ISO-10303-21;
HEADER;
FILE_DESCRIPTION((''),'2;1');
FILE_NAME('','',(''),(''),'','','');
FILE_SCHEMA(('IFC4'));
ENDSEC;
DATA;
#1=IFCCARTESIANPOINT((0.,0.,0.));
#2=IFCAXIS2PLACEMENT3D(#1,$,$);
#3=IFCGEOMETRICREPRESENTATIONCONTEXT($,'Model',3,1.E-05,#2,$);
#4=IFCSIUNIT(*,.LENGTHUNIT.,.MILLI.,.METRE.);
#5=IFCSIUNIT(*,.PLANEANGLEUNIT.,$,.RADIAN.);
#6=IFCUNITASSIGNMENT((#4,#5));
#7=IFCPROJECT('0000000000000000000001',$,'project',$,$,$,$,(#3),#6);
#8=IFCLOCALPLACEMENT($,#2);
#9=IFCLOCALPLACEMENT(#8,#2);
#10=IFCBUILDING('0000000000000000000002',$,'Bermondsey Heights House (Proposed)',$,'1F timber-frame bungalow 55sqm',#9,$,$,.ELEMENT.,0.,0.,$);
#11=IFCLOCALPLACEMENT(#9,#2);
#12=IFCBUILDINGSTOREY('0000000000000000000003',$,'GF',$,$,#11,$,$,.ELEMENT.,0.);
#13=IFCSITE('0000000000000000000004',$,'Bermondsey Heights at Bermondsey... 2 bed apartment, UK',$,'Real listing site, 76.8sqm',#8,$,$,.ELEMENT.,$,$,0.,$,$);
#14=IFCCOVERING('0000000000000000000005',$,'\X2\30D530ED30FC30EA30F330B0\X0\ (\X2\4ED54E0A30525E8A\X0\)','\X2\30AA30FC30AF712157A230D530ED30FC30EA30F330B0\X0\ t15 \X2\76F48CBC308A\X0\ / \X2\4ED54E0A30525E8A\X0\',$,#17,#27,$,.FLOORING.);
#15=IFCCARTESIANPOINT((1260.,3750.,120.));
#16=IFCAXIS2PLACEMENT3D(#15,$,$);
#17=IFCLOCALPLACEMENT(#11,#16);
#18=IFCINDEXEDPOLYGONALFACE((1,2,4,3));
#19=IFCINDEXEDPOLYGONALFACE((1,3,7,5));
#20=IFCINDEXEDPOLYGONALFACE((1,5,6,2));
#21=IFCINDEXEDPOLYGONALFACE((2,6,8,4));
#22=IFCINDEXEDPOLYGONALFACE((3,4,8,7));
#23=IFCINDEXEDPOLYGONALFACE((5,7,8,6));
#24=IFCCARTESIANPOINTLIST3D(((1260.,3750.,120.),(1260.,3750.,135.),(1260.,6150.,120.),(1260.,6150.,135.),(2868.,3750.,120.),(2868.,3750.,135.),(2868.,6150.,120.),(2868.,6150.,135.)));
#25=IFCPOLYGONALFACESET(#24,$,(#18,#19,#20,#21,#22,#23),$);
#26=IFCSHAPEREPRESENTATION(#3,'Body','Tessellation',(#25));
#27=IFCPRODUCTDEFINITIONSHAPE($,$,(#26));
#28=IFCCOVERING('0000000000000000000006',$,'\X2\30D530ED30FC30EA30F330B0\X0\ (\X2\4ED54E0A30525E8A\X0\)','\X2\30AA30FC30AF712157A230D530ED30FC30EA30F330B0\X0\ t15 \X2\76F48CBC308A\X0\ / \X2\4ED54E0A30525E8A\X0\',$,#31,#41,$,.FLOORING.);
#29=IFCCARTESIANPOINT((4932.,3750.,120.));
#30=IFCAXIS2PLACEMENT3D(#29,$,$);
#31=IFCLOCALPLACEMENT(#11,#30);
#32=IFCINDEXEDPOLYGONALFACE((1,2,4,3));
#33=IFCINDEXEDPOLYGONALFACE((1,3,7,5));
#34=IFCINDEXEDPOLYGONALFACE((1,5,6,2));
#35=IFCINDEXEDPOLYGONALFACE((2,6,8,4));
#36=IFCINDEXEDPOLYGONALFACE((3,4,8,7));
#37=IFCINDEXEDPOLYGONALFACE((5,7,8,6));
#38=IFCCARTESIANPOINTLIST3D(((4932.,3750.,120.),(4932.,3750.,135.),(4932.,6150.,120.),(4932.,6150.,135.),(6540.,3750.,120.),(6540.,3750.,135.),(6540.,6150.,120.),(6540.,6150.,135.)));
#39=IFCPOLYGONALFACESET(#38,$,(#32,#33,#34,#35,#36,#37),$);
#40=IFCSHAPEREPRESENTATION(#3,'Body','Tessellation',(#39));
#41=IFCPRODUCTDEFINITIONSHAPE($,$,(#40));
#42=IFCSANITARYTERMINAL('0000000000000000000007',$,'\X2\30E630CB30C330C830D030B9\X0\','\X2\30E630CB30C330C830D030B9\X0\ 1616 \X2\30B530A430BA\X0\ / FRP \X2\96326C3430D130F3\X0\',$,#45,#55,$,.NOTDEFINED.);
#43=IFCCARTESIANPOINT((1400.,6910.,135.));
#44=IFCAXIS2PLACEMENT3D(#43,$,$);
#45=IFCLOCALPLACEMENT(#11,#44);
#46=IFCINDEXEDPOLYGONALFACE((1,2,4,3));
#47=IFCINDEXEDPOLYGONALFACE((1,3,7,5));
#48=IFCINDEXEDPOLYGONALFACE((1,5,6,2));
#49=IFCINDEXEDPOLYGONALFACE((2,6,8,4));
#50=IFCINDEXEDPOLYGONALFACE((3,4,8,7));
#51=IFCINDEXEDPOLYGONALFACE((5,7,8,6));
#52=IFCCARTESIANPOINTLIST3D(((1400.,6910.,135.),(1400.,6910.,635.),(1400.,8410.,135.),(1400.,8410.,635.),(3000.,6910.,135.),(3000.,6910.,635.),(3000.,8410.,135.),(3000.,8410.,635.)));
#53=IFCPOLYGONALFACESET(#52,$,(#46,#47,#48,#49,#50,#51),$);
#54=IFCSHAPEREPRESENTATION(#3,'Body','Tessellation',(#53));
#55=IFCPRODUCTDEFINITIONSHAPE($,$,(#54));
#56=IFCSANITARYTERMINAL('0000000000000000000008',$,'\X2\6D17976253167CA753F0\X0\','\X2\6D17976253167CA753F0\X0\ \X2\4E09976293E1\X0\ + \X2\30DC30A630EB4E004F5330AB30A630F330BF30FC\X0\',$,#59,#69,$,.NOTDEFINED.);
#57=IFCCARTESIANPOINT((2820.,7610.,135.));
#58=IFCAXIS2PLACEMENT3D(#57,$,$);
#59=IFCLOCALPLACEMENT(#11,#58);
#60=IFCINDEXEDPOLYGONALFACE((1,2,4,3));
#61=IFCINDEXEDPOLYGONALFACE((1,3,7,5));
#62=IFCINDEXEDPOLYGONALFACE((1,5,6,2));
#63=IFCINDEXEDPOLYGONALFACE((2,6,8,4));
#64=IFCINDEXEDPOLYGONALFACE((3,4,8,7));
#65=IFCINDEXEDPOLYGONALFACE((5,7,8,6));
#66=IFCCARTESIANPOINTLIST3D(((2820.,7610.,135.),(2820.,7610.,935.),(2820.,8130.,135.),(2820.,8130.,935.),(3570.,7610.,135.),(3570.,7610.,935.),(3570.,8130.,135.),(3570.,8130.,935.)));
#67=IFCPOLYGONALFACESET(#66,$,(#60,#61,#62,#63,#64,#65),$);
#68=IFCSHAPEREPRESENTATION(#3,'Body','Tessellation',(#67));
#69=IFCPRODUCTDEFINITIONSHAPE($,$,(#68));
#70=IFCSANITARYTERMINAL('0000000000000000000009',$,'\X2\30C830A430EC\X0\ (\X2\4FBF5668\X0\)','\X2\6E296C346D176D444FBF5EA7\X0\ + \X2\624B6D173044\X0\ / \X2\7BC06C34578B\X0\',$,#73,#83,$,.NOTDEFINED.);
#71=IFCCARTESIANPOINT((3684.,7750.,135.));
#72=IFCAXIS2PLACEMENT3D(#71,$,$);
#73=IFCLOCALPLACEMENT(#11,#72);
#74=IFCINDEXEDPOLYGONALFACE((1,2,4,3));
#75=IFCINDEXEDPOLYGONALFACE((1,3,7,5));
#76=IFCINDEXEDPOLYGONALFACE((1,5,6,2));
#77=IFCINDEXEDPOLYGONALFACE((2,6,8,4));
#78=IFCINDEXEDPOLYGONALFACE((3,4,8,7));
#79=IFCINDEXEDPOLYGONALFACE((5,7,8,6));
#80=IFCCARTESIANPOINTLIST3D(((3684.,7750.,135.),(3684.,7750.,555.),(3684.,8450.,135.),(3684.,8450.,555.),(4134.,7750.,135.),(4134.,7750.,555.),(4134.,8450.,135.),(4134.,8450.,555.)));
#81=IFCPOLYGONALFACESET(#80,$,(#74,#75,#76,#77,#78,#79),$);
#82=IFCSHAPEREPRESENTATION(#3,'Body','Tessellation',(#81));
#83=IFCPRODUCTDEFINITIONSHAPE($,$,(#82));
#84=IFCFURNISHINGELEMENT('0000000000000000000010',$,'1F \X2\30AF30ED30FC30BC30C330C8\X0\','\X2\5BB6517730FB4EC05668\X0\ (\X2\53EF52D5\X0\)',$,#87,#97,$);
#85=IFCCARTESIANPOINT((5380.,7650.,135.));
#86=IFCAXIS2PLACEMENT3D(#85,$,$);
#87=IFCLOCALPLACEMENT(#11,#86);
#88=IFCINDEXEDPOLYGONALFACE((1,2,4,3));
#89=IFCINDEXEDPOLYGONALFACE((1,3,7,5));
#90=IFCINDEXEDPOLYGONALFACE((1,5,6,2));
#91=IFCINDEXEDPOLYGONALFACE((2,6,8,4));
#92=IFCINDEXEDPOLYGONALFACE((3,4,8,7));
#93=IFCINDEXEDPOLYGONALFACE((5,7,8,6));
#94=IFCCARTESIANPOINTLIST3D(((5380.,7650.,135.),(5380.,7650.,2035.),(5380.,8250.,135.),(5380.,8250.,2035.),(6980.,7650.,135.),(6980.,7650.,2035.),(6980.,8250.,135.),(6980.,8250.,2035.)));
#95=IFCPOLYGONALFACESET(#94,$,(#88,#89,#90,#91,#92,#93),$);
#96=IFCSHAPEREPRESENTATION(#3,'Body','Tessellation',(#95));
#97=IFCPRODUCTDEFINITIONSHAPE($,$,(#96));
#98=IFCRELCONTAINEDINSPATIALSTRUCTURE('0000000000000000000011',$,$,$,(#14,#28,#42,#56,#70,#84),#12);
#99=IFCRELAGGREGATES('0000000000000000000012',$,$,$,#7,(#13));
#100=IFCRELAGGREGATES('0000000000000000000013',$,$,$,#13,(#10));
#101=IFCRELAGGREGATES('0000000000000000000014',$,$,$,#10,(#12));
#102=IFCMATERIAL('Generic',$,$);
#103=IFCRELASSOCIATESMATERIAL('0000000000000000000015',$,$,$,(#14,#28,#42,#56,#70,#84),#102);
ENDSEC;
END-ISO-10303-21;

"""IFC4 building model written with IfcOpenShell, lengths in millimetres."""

from ifc_helpers import new_model, si_unit, frame, frame_2d, origin, place, context, project, spatial, rectangle, extrude, material, element, save


model = new_model("IFC4")

# Units and contexts
model_context = context("Model", 3, precision=1e-05, world=origin())
ifc_project = project(units=[si_unit("LENGTHUNIT", "METRE", prefix="MILLI"), si_unit("PLANEANGLEUNIT", "RADIAN")], contexts=[model_context])

# Site, building, storey
site_placement = place(None, origin())
site = spatial("IfcSite", under=ifc_project, at=site_placement, Name="Bermondsey Heights at Bermondsey... 2 bed apartment, UK", ObjectType="Real listing site, 76.8sqm", CompositionType="ELEMENT", RefElevation=0.0)
building_placement = place(site_placement, origin())
building = spatial("IfcBuilding", under=site, at=building_placement, Name="Bermondsey Heights House (Proposed)", ObjectType="1F timber-frame bungalow 55sqm", CompositionType="ELEMENT", ElevationOfRefHeight=0.0, ElevationOfTerrain=0.0)
storey_placement = place(building_placement, origin())
storey = spatial("IfcBuildingStorey", under=building, at=storey_placement, Name="GF", CompositionType="ELEMENT", Elevation=0.0)

# Coverings
ifc_material_1 = material(Name="Generic")
covering_1_placement = place(storey_placement, frame((1260.0, 3750.0, 120.0)))
element("IfcCovering", 1, at=covering_1_placement, inside=storey, material=ifc_material_1, Name="フローリング (仕上げ床)", Description="オーク無垢フローリング t15 直貼り / 仕上げ床", PredefinedType="FLOORING", context=model_context, shape_type="SweptSolid", body=[
    extrude(rectangle(XDim=1608.0, YDim=2400.0, at=frame_2d((804.0, 1200.0))), frame((1260.0, 3750.0, 120.0)), (0.0, 0.0, 1.0), 15.0),
])
covering_2_placement = place(storey_placement, frame((4932.0, 3750.0, 120.0)))
element("IfcCovering", 2, at=covering_2_placement, inside=storey, material=ifc_material_1, Name="フローリング (仕上げ床)", Description="オーク無垢フローリング t15 直貼り / 仕上げ床", PredefinedType="FLOORING", context=model_context, shape_type="SweptSolid", body=[
    extrude(rectangle(XDim=1608.0, YDim=2400.0, at=frame_2d((804.0, 1200.0))), frame((4932.0, 3750.0, 120.0)), (0.0, 0.0, 1.0), 15.0),
])

# Sanitary terminals
sanitary_terminal_1_placement = place(storey_placement, frame((1400.0, 6910.0, 135.0)))
element("IfcSanitaryTerminal", 3, at=sanitary_terminal_1_placement, inside=storey, material=ifc_material_1, Name="ユニットバス", Description="ユニットバス 1616 サイズ / FRP 防水パン", PredefinedType="NOTDEFINED", context=model_context, shape_type="SweptSolid", body=[
    extrude(rectangle(XDim=1600.0, YDim=1500.0, at=frame_2d((800.0, 750.0))), frame((1400.0, 6910.0, 135.0)), (0.0, 0.0, 1.0), 500.0),
])
sanitary_terminal_2_placement = place(storey_placement, frame((2820.0, 7610.0, 135.0)))
element("IfcSanitaryTerminal", 4, at=sanitary_terminal_2_placement, inside=storey, material=ifc_material_1, Name="洗面化粧台", Description="洗面化粧台 三面鏡 + ボウル一体カウンター", PredefinedType="NOTDEFINED", context=model_context, shape_type="SweptSolid", body=[
    extrude(rectangle(XDim=750.0, YDim=520.0, at=frame_2d((375.0, 260.0))), frame((2820.0, 7610.0, 135.0)), (0.0, 0.0, 1.0), 800.0),
])
sanitary_terminal_3_placement = place(storey_placement, frame((3684.0, 7750.0, 135.0)))
element("IfcSanitaryTerminal", 5, at=sanitary_terminal_3_placement, inside=storey, material=ifc_material_1, Name="トイレ (便器)", Description="温水洗浄便座 + 手洗い / 節水型", PredefinedType="NOTDEFINED", context=model_context, shape_type="SweptSolid", body=[
    extrude(rectangle(XDim=450.0, YDim=700.0, at=frame_2d((225.0, 350.0))), frame((3684.0, 7750.0, 135.0)), (0.0, 0.0, 1.0), 420.0),
])

# Furnishing element
furnishing_placement = place(storey_placement, frame((5380.0, 7650.0, 135.0)))
element("IfcFurnishingElement", 6, at=furnishing_placement, inside=storey, material=ifc_material_1, Name="1F クローゼット", Description="家具・什器 (可動)", context=model_context, shape_type="SweptSolid", body=[
    extrude(rectangle(XDim=1600.0, YDim=600.0, at=frame_2d((800.0, 300.0))), frame((5380.0, 7650.0, 135.0)), (0.0, 0.0, 1.0), 1900.0),
])

save(model, "model.ifc")
